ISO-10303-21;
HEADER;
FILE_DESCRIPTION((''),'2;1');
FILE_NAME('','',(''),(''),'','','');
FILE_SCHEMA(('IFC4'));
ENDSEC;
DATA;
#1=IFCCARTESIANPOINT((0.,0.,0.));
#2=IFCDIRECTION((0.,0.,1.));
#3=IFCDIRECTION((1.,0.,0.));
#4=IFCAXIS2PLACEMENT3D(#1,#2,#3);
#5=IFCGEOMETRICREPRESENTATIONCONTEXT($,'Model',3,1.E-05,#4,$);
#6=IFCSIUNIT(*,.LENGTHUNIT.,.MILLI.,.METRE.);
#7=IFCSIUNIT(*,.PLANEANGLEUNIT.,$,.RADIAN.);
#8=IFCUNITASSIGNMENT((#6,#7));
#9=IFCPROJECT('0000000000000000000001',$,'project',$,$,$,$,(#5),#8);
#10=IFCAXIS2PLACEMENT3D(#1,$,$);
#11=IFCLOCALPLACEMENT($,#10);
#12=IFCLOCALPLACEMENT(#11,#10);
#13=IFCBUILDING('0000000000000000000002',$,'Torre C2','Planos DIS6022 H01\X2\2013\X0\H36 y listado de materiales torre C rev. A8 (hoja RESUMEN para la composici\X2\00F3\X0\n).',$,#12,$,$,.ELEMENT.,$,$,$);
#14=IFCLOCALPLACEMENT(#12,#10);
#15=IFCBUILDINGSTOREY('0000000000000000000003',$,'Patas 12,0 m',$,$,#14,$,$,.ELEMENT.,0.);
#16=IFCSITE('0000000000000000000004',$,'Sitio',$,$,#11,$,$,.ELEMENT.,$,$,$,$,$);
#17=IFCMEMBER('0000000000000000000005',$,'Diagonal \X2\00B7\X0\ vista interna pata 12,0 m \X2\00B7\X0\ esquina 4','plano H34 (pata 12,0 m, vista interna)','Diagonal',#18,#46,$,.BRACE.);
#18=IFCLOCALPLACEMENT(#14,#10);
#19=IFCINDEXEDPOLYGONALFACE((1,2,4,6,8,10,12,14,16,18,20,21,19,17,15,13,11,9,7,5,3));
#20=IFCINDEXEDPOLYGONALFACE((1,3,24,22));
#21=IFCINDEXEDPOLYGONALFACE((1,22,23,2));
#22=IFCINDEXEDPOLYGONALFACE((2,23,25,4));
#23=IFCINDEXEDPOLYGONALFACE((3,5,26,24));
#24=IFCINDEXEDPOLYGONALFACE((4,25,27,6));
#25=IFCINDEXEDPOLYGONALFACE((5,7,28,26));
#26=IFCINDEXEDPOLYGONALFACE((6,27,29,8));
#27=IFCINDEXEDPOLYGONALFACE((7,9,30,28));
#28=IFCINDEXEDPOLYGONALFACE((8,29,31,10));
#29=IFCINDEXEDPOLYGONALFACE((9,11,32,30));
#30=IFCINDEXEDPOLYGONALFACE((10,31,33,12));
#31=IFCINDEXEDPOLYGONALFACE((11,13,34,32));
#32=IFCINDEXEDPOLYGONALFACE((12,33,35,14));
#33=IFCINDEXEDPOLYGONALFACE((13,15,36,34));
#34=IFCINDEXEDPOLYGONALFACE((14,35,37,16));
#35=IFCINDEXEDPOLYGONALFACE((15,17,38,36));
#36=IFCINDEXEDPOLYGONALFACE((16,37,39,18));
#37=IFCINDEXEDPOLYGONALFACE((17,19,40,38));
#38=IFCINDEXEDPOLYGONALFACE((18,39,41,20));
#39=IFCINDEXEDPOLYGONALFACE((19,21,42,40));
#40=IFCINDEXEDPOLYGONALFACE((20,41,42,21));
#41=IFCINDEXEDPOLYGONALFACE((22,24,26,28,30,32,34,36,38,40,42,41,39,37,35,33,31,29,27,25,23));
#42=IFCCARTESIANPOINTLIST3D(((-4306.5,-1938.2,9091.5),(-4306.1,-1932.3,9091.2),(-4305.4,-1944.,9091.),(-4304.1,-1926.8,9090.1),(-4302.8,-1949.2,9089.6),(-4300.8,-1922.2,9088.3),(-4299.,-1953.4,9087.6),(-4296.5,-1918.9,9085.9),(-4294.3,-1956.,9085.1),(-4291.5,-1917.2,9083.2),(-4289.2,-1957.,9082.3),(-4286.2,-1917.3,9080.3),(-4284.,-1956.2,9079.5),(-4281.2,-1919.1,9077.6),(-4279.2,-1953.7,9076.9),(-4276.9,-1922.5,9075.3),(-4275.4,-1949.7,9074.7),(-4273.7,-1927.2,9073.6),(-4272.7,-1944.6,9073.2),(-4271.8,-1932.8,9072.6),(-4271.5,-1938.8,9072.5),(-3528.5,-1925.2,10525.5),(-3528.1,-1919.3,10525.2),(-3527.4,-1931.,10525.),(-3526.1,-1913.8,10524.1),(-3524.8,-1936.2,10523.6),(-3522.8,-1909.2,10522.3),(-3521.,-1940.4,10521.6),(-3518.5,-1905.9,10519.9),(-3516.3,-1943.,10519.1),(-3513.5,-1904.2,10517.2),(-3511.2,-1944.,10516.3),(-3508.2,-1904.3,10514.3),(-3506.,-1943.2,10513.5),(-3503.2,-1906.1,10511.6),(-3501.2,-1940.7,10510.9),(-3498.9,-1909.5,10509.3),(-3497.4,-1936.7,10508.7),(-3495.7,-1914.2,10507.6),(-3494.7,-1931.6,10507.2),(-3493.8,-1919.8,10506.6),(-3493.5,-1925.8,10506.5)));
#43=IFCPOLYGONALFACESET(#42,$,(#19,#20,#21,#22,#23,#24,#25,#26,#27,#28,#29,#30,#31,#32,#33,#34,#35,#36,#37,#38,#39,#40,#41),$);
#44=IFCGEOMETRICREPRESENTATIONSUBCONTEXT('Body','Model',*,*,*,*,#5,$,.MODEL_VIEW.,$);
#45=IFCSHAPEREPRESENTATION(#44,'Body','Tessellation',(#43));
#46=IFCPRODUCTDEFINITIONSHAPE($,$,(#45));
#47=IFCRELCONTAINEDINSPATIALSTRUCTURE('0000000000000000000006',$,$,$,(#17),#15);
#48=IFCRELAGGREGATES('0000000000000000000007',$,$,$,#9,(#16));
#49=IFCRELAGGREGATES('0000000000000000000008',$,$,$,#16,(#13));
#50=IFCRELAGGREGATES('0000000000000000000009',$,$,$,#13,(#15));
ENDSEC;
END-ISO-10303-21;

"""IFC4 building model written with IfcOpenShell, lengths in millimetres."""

from ifc_helpers import new_model, si_unit, frame, origin, origin_with_axes, place, context, subcontext, project, spatial, circle, extrude, element, save


model = new_model("IFC4")

# Units and contexts
model_context = context("Model", 3, precision=1e-05, world=origin_with_axes())
body_context = subcontext(model_context, "Body", "Model", "MODEL_VIEW")
ifc_project = project(units=[si_unit("LENGTHUNIT", "METRE", prefix="MILLI"), si_unit("PLANEANGLEUNIT", "RADIAN")], contexts=[model_context])

# Site, building, storey
site_placement = place(None, origin())
site = spatial("IfcSite", under=ifc_project, at=site_placement, Name="Sitio", CompositionType="ELEMENT")
building_placement = place(site_placement, origin())
building = spatial("IfcBuilding", under=site, at=building_placement, Name="Torre C2", Description="Planos DIS6022 H01–H36 y listado de materiales torre C rev. A8 (hoja RESUMEN para la composición).", CompositionType="ELEMENT")
storey_placement = place(building_placement, origin())
storey = spatial("IfcBuildingStorey", under=building, at=storey_placement, Name="Patas 12,0 m", CompositionType="ELEMENT", Elevation=0.0)

# Member
member_1_placement = place(storey_placement, frame((-4289.0, -1937.0, 9082.0), z_axis=(0.47686, 0.007968, 0.878943), x_axis=(0.76544, 0.487802, -0.419703)))
element("IfcMember", 1, at=member_1_placement, inside=storey, Name="Diagonal · vista interna pata 12,0 m · esquina 4", Description="plano H34 (pata 12,0 m, vista interna)", ObjectType="Diagonal", PredefinedType="BRACE", context=body_context, shape_type="SweptSolid", body=[
    extrude(circle(Radius=20.0), None, (0.0, 0.0, 1.0), 1631.5),
])

save(model, "model.ifc")
